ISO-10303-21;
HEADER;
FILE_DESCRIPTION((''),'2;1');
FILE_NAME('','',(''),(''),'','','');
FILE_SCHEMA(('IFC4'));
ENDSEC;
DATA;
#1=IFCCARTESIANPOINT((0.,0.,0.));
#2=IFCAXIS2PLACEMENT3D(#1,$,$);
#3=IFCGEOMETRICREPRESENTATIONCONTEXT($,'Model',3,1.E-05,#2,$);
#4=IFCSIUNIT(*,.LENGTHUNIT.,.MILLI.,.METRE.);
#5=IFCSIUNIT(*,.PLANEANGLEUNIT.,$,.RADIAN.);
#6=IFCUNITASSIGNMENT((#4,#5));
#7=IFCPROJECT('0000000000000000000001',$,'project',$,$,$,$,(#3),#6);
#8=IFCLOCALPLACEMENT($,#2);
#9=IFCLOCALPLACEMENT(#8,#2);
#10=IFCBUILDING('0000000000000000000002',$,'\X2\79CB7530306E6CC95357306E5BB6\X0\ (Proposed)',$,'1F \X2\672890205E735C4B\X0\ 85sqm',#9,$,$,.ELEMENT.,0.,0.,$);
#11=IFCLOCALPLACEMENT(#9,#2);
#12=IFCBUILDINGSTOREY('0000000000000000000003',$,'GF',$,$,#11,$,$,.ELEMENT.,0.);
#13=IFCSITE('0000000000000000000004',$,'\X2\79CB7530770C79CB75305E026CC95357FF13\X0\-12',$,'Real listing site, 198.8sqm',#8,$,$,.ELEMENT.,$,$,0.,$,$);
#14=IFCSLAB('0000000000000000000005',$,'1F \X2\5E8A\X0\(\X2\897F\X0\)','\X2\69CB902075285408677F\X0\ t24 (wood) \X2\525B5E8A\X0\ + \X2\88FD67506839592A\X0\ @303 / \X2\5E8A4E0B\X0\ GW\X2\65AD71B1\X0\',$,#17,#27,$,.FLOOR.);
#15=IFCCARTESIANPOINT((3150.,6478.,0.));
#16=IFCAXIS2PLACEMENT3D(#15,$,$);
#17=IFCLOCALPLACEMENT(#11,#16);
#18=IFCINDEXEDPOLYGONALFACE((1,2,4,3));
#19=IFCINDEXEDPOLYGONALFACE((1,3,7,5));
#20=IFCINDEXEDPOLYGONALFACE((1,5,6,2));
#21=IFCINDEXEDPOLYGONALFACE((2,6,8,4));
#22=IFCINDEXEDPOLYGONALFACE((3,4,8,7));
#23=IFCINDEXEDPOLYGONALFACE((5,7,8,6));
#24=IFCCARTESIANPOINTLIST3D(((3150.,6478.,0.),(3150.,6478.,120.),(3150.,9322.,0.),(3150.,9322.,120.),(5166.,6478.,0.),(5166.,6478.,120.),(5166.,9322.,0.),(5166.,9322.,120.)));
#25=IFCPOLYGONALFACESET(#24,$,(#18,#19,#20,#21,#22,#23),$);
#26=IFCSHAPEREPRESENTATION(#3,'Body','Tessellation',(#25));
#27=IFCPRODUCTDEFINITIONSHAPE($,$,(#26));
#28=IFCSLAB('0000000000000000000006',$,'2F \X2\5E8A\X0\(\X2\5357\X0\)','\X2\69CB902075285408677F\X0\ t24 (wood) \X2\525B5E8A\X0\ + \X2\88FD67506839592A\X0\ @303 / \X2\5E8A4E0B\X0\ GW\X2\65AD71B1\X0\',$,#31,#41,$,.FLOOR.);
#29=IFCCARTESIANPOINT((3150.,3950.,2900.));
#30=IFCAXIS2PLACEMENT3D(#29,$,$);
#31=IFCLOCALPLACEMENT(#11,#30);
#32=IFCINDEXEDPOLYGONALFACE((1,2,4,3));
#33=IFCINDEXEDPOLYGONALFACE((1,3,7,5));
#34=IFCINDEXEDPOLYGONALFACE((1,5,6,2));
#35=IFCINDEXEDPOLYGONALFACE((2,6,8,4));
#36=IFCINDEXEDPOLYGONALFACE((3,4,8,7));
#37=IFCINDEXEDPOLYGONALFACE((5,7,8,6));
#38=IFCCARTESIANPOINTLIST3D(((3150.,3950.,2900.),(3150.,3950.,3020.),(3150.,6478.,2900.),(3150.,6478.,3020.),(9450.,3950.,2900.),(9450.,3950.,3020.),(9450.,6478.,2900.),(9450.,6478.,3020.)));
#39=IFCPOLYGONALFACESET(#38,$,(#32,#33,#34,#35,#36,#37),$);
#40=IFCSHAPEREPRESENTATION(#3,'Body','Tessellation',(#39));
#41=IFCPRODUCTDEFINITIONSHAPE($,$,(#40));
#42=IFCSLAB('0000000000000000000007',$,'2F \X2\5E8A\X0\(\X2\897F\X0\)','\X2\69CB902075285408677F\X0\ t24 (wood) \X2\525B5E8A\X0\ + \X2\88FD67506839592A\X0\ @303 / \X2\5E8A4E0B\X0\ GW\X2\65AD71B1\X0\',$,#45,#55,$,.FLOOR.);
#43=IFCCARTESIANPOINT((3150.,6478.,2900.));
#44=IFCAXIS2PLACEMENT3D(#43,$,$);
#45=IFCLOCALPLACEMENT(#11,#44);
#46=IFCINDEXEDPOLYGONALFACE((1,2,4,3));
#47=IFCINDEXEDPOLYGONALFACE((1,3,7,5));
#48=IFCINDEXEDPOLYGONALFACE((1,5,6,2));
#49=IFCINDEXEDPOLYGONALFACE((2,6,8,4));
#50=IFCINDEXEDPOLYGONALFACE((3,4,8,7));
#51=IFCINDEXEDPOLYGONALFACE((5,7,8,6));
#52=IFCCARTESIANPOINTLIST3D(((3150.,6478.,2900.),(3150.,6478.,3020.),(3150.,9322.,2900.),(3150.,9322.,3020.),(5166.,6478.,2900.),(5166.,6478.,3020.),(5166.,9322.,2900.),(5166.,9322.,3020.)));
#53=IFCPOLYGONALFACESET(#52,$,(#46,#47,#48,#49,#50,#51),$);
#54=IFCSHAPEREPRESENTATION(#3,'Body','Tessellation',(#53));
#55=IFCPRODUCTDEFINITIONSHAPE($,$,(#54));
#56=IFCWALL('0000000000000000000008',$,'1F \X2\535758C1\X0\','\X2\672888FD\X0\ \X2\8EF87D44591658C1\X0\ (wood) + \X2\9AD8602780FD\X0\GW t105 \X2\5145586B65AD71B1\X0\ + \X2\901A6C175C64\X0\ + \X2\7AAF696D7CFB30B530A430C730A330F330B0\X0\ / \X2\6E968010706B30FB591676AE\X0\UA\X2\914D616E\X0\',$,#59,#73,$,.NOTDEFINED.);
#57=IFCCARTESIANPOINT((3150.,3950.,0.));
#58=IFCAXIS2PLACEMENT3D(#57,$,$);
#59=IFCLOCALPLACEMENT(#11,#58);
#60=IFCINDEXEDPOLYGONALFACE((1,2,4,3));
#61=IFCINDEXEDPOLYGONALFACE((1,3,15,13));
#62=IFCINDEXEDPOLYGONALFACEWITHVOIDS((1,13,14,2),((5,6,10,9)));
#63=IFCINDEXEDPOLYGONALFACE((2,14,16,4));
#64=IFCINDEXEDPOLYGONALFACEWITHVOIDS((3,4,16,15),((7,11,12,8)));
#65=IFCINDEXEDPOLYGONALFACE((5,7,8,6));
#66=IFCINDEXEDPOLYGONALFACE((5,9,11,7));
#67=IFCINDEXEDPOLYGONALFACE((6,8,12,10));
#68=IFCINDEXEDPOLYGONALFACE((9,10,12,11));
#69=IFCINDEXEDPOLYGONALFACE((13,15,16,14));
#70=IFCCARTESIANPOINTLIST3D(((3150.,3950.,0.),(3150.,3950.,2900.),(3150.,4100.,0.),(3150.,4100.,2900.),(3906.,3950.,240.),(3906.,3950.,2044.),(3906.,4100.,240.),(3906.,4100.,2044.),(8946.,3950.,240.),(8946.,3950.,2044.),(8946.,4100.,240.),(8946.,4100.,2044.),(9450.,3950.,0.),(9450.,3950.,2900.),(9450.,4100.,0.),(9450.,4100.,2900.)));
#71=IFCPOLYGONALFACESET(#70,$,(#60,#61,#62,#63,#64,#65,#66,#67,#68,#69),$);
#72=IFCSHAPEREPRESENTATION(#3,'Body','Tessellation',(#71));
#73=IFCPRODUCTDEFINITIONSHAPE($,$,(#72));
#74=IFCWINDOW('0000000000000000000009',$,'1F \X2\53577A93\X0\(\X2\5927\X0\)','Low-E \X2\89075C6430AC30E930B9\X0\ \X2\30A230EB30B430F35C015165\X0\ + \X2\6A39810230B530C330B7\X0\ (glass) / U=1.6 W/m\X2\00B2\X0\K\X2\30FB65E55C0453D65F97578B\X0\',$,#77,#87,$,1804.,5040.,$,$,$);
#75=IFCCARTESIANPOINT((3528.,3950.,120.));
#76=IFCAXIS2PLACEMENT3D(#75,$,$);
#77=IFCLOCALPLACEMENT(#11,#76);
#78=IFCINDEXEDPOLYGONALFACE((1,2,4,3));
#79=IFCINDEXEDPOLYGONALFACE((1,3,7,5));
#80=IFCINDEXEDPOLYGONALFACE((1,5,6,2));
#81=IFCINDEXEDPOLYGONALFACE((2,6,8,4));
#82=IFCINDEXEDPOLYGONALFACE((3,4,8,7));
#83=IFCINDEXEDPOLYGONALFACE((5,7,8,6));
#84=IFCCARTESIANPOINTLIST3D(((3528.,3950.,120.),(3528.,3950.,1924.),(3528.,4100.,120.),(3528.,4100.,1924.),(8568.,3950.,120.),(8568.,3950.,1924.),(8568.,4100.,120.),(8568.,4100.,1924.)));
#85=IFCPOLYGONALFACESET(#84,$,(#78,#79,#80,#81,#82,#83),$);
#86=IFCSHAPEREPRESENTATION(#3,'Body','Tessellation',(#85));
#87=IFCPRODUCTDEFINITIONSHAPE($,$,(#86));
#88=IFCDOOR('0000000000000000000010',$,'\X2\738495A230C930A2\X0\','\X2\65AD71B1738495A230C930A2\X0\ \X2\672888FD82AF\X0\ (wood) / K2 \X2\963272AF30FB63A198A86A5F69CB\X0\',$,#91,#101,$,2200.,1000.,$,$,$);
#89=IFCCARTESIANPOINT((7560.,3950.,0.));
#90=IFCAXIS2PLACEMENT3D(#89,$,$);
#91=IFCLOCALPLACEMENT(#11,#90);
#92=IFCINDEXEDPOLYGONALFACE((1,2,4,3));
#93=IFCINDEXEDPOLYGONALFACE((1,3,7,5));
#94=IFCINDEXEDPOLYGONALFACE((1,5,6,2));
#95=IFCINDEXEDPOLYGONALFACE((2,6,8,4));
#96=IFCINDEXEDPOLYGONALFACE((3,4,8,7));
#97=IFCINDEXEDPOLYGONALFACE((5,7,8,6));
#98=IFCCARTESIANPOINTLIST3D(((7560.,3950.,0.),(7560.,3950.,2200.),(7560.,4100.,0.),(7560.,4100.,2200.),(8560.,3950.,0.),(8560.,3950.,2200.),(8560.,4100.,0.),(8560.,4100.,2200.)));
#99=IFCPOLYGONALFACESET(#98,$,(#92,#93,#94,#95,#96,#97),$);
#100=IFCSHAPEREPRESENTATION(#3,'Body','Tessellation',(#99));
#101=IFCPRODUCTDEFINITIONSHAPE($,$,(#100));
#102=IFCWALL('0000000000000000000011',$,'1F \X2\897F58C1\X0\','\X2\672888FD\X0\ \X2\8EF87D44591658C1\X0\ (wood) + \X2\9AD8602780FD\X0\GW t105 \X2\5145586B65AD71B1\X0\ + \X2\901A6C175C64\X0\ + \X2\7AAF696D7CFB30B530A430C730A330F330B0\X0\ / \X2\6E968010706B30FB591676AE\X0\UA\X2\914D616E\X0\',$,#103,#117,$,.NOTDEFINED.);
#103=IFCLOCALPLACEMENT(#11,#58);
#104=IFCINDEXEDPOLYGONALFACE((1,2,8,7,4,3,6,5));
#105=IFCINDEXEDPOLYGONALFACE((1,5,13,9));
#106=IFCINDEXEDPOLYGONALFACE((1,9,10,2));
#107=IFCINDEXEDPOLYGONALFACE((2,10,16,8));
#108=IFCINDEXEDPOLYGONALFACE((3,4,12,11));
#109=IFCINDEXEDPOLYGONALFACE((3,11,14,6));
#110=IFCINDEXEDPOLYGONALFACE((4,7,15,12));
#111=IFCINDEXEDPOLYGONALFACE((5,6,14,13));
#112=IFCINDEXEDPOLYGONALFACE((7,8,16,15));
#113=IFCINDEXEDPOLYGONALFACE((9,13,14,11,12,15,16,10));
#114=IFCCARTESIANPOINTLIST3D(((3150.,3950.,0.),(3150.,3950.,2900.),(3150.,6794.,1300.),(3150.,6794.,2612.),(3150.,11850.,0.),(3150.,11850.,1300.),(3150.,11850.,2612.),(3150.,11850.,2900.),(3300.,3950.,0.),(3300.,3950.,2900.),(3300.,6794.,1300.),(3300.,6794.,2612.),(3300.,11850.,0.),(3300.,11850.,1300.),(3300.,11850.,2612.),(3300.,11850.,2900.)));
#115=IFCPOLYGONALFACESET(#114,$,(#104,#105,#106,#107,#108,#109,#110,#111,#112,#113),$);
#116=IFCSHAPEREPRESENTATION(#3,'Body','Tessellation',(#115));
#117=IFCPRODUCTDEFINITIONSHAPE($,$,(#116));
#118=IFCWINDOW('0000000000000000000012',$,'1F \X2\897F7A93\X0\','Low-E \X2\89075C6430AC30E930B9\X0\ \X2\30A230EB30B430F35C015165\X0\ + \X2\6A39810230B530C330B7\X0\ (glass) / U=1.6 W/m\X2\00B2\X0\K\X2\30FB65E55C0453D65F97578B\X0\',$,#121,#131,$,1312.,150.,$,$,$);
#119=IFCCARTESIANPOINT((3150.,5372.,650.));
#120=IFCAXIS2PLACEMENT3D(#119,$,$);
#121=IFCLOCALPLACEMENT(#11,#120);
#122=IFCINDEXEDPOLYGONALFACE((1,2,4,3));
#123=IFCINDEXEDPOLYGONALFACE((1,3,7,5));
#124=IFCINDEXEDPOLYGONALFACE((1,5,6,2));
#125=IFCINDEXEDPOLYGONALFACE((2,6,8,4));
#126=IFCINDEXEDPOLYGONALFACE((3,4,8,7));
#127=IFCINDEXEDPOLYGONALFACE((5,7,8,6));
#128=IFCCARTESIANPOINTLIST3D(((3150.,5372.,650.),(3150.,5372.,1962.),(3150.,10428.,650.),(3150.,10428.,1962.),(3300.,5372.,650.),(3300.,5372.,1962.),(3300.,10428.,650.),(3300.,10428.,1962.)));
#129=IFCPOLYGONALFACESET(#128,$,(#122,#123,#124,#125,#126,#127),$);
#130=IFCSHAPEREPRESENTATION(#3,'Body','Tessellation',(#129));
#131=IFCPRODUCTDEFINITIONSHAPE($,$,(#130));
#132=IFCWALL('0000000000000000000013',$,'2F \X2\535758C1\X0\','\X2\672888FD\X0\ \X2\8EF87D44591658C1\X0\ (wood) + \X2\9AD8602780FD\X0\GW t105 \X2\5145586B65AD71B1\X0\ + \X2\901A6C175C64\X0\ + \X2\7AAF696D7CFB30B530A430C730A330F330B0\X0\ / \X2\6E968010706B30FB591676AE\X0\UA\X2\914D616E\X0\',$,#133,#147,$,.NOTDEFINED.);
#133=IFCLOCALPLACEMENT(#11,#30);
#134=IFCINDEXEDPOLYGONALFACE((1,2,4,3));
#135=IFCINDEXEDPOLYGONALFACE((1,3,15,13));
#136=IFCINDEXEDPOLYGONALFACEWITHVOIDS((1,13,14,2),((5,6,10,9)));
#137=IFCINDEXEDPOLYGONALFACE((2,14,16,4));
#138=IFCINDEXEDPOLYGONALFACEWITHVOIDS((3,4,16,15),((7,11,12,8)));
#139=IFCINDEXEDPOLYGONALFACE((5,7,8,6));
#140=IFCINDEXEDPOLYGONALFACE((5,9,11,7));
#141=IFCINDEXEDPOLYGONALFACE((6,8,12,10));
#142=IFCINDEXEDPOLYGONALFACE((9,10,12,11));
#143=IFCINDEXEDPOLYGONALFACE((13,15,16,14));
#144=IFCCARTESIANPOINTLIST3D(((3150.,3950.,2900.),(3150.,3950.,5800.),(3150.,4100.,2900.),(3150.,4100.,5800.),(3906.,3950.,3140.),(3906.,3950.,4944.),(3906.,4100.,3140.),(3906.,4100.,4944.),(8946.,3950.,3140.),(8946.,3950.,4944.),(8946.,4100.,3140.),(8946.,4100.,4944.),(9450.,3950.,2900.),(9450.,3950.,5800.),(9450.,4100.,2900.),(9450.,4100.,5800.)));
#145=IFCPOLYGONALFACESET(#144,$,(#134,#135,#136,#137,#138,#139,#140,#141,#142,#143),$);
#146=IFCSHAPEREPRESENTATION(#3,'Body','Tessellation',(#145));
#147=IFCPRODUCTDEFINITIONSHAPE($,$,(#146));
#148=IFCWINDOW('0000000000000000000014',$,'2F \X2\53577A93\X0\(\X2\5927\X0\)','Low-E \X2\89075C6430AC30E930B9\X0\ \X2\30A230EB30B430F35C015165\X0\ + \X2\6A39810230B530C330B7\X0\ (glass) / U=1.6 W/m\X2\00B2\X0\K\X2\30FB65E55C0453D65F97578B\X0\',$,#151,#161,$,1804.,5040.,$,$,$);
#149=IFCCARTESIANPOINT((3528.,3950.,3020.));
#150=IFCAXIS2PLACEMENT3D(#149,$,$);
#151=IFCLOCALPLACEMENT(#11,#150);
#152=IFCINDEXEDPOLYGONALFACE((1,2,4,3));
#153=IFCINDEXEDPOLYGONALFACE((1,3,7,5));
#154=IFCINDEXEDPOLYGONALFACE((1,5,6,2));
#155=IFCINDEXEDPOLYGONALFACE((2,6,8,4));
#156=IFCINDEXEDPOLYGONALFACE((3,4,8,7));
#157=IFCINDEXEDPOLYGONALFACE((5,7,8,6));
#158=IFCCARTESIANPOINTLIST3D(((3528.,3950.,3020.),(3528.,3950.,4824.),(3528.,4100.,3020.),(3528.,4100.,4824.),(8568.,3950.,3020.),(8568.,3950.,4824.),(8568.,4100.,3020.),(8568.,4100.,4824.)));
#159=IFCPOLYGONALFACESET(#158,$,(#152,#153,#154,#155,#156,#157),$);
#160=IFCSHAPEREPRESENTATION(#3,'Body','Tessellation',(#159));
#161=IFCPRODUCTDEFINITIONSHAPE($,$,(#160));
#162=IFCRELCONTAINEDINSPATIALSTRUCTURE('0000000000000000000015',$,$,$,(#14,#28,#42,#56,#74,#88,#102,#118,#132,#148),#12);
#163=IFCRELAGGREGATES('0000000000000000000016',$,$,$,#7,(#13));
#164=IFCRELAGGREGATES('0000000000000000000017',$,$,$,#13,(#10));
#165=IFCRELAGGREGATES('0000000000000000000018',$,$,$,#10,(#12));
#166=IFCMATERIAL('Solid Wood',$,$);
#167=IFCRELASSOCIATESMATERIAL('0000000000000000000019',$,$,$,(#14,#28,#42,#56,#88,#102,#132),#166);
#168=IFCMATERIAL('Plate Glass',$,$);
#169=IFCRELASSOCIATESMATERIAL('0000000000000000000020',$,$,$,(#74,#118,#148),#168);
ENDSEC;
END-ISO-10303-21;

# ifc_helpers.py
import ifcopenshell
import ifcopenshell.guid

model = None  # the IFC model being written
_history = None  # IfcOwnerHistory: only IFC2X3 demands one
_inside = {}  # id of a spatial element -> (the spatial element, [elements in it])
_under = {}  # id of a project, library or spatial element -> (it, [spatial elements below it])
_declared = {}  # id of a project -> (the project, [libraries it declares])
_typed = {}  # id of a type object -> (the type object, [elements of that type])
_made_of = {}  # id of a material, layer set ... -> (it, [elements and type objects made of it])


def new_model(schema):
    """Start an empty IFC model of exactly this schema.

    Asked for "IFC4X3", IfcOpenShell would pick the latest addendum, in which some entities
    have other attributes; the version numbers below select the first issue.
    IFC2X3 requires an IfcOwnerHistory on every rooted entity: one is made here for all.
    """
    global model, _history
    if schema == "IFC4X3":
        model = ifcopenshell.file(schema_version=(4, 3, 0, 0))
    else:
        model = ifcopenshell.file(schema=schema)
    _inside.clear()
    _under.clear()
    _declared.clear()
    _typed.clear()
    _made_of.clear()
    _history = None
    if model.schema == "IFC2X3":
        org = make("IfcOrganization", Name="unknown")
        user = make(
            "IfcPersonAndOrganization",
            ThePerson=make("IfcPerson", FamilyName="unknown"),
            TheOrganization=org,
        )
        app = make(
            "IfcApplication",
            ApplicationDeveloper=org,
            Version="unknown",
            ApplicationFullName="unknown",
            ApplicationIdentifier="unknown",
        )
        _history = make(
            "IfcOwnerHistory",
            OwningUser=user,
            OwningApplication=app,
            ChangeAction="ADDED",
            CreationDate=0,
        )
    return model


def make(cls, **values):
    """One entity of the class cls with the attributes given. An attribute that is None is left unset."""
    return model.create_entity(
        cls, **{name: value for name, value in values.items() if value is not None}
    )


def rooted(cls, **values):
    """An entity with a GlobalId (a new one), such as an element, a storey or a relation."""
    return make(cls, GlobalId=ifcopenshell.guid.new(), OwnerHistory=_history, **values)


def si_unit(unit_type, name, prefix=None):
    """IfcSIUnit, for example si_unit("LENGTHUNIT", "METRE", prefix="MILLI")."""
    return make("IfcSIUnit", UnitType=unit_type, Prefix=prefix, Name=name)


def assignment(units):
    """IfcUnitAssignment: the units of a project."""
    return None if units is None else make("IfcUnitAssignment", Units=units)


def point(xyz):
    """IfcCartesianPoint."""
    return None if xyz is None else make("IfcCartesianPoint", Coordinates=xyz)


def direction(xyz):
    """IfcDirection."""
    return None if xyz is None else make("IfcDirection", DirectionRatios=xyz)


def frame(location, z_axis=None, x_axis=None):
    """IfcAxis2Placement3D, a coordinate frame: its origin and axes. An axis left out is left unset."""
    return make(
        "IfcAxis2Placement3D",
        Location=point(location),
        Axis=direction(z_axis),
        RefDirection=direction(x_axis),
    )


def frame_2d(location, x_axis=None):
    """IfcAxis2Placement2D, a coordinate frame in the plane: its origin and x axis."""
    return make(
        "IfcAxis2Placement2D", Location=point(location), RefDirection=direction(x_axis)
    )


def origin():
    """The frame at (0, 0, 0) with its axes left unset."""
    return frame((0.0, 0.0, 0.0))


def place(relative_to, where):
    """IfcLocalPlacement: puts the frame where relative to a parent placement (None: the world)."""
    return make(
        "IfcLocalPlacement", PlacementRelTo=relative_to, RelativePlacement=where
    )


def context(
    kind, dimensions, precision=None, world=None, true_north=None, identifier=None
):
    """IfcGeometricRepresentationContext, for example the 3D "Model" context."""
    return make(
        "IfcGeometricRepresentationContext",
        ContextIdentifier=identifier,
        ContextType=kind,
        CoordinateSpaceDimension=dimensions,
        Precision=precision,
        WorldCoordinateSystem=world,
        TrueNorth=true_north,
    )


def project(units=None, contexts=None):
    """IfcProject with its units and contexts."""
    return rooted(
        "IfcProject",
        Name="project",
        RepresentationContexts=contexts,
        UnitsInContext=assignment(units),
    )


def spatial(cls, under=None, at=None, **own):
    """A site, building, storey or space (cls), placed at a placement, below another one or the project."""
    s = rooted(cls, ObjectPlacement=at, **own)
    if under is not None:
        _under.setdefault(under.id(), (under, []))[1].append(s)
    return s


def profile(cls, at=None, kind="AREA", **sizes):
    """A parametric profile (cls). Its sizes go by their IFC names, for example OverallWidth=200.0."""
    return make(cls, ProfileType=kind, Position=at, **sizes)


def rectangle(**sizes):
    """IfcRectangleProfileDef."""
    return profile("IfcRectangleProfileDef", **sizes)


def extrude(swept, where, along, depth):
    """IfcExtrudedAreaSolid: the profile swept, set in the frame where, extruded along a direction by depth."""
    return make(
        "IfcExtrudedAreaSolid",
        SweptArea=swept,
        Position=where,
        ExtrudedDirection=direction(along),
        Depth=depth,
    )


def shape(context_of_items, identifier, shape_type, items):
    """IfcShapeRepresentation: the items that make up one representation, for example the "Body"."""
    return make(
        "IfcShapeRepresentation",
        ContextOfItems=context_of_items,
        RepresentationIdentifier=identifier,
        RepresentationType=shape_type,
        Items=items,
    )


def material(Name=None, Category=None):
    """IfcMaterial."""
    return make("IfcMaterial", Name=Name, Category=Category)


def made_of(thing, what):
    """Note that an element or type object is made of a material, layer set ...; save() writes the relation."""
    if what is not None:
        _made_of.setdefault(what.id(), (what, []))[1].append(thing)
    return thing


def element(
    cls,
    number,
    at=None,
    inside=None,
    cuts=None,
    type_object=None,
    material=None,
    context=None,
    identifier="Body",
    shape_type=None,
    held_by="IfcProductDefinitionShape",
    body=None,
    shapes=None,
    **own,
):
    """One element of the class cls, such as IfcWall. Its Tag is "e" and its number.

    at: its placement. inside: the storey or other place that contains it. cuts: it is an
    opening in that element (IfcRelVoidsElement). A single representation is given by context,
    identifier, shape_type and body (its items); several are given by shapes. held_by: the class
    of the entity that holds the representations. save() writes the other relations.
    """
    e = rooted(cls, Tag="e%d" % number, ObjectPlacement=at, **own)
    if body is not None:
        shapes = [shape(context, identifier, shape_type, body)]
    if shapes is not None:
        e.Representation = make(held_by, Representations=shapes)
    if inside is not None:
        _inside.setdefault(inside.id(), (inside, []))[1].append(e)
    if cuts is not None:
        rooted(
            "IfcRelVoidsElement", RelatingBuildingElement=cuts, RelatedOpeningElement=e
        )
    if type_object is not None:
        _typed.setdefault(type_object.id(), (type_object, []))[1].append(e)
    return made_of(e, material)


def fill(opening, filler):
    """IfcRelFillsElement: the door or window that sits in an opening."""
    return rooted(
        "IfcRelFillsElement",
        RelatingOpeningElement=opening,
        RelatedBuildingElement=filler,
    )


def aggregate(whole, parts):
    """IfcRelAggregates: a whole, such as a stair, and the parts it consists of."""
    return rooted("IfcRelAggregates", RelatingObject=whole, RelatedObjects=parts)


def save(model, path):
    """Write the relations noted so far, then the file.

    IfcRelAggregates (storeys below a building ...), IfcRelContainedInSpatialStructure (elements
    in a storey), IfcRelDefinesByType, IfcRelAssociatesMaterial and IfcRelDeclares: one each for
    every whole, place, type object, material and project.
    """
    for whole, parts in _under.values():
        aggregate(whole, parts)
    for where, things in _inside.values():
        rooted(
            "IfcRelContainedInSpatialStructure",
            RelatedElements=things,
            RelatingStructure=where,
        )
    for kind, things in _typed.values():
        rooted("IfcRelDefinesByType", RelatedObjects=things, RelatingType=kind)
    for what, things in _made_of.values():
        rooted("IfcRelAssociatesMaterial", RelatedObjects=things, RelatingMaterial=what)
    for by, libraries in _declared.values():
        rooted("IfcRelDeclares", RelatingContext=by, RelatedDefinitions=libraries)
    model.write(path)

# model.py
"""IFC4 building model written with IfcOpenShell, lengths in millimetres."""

from ifc_helpers import new_model, si_unit, frame, frame_2d, origin, place, context, project, spatial, rectangle, extrude, material, element, fill, save


model = new_model("IFC4")

# Units and contexts
model_context = context("Model", 3, precision=1e-05, world=origin())
ifc_project = project(units=[si_unit("LENGTHUNIT", "METRE", prefix="MILLI"), si_unit("PLANEANGLEUNIT", "RADIAN")], contexts=[model_context])

# Site, building, storey
site_placement = place(None, origin())
site = spatial("IfcSite", under=ifc_project, at=site_placement, Name="秋田県秋田市泉南３-12", ObjectType="Real listing site, 198.8sqm", CompositionType="ELEMENT", RefElevation=0.0)
building_placement = place(site_placement, origin())
building = spatial("IfcBuilding", under=site, at=building_placement, Name="秋田の泉南の家 (Proposed)", ObjectType="1F 木造平屋 85sqm", CompositionType="ELEMENT", ElevationOfRefHeight=0.0, ElevationOfTerrain=0.0)
storey_placement = place(building_placement, origin())
storey = spatial("IfcBuildingStorey", under=building, at=storey_placement, Name="GF", CompositionType="ELEMENT", Elevation=0.0)

# Slabs
ifc_material_1 = material(Name="Solid Wood")
slab_1_placement = place(storey_placement, frame((3150.0, 6478.0, 0.0)))
element("IfcSlab", 1, at=slab_1_placement, inside=storey, material=ifc_material_1, Name="1F 床(西)", Description="構造用合板 t24 (wood) 剛床 + 製材根太 @303 / 床下 GW断熱", PredefinedType="FLOOR", context=model_context, shape_type="SweptSolid", body=[
    extrude(rectangle(XDim=2016.0, YDim=2844.0, at=frame_2d((1008.0, 1422.0))), frame((3150.0, 6478.0, 0.0)), (0.0, 0.0, 1.0), 120.0),
])
slab_2_placement = place(storey_placement, frame((3150.0, 3950.0, 2900.0)))
element("IfcSlab", 2, at=slab_2_placement, inside=storey, material=ifc_material_1, Name="2F 床(南)", Description="構造用合板 t24 (wood) 剛床 + 製材根太 @303 / 床下 GW断熱", PredefinedType="FLOOR", context=model_context, shape_type="SweptSolid", body=[
    extrude(rectangle(XDim=6300.0, YDim=2528.0, at=frame_2d((3150.0, 1264.0))), frame((3150.0, 3950.0, 2900.0)), (0.0, 0.0, 1.0), 120.0),
])
slab_3_placement = place(storey_placement, frame((3150.0, 6478.0, 2900.0)))
element("IfcSlab", 3, at=slab_3_placement, inside=storey, material=ifc_material_1, Name="2F 床(西)", Description="構造用合板 t24 (wood) 剛床 + 製材根太 @303 / 床下 GW断熱", PredefinedType="FLOOR", context=model_context, shape_type="SweptSolid", body=[
    extrude(rectangle(XDim=2016.0, YDim=2844.0, at=frame_2d((1008.0, 1422.0))), frame((3150.0, 6478.0, 2900.0)), (0.0, 0.0, 1.0), 120.0),
])

# Wall, openings, window, door
wall_1_placement = place(storey_placement, frame((3150.0, 3950.0, 0.0)))
wall_1 = element("IfcWall", 4, at=wall_1_placement, inside=storey, material=ifc_material_1, Name="1F 南壁", Description="木製 軸組外壁 (wood) + 高性能GW t105 充填断熱 + 通気層 + 窯業系サイディング / 準耐火・外皮UA配慮", PredefinedType="NOTDEFINED", context=model_context, shape_type="SweptSolid", body=[
    extrude(rectangle(XDim=6300.0, YDim=150.0, at=frame_2d((3150.0, 75.0))), frame((3150.0, 3950.0, 0.0)), (0.0, 0.0, 1.0), 2900.0),
])
opening_1_placement = place(storey_placement, frame((3528.0, 3950.0, 120.0)))
opening_1 = element("IfcOpeningElement", 5, at=opening_1_placement, cuts=wall_1, PredefinedType="NOTDEFINED", context=model_context, shape_type="SweptSolid", body=[
    extrude(rectangle(XDim=5040.0, YDim=150.0, at=frame_2d((2520.0, 75.0))), frame((3528.0, 3950.0, 120.0)), (0.0, 0.0, 1.0), 1804.0),
])
opening_2_placement = place(storey_placement, frame((7560.0, 3950.0, 0.0)))
opening_2 = element("IfcOpeningElement", 6, at=opening_2_placement, cuts=wall_1, PredefinedType="NOTDEFINED", context=model_context, shape_type="SweptSolid", body=[
    extrude(rectangle(XDim=1000.0, YDim=150.0, at=frame_2d((500.0, 75.0))), frame((7560.0, 3950.0, 0.0)), (0.0, 0.0, 1.0), 2200.0),
])
ifc_material_2 = material(Name="Plate Glass")
window_1_placement = place(storey_placement, frame((3528.0, 3950.0, 120.0)))
window_1 = element("IfcWindow", 7, at=window_1_placement, inside=storey, material=ifc_material_2, Name="1F 南窓(大)", Description="Low-E 複層ガラス アルゴン封入 + 樹脂サッシ (glass) / U=1.6 W/m²K・日射取得型", OverallHeight=1804.0, OverallWidth=5040.0, context=model_context, shape_type="SweptSolid", body=[
    extrude(rectangle(XDim=5040.0, YDim=150.0, at=frame_2d((2520.0, 75.0))), frame((3528.0, 3950.0, 120.0)), (0.0, 0.0, 1.0), 1804.0),
])
fill(opening_1, window_1)
door_placement = place(storey_placement, frame((7560.0, 3950.0, 0.0)))
door = element("IfcDoor", 8, at=door_placement, inside=storey, material=ifc_material_1, Name="玄関ドア", Description="断熱玄関ドア 木製芯 (wood) / K2 防犯・採風機構", OverallHeight=2200.0, OverallWidth=1000.0, context=model_context, shape_type="SweptSolid", body=[
    extrude(rectangle(XDim=1000.0, YDim=150.0, at=frame_2d((500.0, 75.0))), frame((7560.0, 3950.0, 0.0)), (0.0, 0.0, 1.0), 2200.0),
])
fill(opening_2, door)

# Walls, openings, windows
wall_2_placement = place(storey_placement, frame((3150.0, 3950.0, 0.0)))
wall_2 = element("IfcWall", 9, at=wall_2_placement, inside=storey, material=ifc_material_1, Name="1F 西壁", Description="木製 軸組外壁 (wood) + 高性能GW t105 充填断熱 + 通気層 + 窯業系サイディング / 準耐火・外皮UA配慮", PredefinedType="NOTDEFINED", context=model_context, shape_type="SweptSolid", body=[
    extrude(rectangle(XDim=150.0, YDim=7900.0, at=frame_2d((75.0, 3950.0))), frame((3150.0, 3950.0, 0.0)), (0.0, 0.0, 1.0), 2900.0),
])
opening_3_placement = place(storey_placement, frame((3150.0, 5372.0, 650.0)))
opening_3 = element("IfcOpeningElement", 10, at=opening_3_placement, cuts=wall_2, PredefinedType="NOTDEFINED", context=model_context, shape_type="SweptSolid", body=[
    extrude(rectangle(XDim=150.0, YDim=5056.0, at=frame_2d((75.0, 2528.0))), frame((3150.0, 5372.0, 650.0)), (0.0, 0.0, 1.0), 1312.0),
])
window_2_placement = place(storey_placement, frame((3150.0, 5372.0, 650.0)))
window_2 = element("IfcWindow", 11, at=window_2_placement, inside=storey, material=ifc_material_2, Name="1F 西窓", Description="Low-E 複層ガラス アルゴン封入 + 樹脂サッシ (glass) / U=1.6 W/m²K・日射取得型", OverallHeight=1312.0, OverallWidth=150.0, context=model_context, shape_type="SweptSolid", body=[
    extrude(rectangle(XDim=150.0, YDim=5056.0, at=frame_2d((75.0, 2528.0))), frame((3150.0, 5372.0, 650.0)), (0.0, 0.0, 1.0), 1312.0),
])
fill(opening_3, window_2)
wall_3_placement = place(storey_placement, frame((3150.0, 3950.0, 2900.0)))
wall_3 = element("IfcWall", 12, at=wall_3_placement, inside=storey, material=ifc_material_1, Name="2F 南壁", Description="木製 軸組外壁 (wood) + 高性能GW t105 充填断熱 + 通気層 + 窯業系サイディング / 準耐火・外皮UA配慮", PredefinedType="NOTDEFINED", context=model_context, shape_type="SweptSolid", body=[
    extrude(rectangle(XDim=6300.0, YDim=150.0, at=frame_2d((3150.0, 75.0))), frame((3150.0, 3950.0, 2900.0)), (0.0, 0.0, 1.0), 2900.0),
])
opening_4_placement = place(storey_placement, frame((3528.0, 3950.0, 3020.0)))
opening_4 = element("IfcOpeningElement", 13, at=opening_4_placement, cuts=wall_3, PredefinedType="NOTDEFINED", context=model_context, shape_type="SweptSolid", body=[
    extrude(rectangle(XDim=5040.0, YDim=150.0, at=frame_2d((2520.0, 75.0))), frame((3528.0, 3950.0, 3020.0)), (0.0, 0.0, 1.0), 1804.0),
])
window_3_placement = place(storey_placement, frame((3528.0, 3950.0, 3020.0)))
window_3 = element("IfcWindow", 14, at=window_3_placement, inside=storey, material=ifc_material_2, Name="2F 南窓(大)", Description="Low-E 複層ガラス アルゴン封入 + 樹脂サッシ (glass) / U=1.6 W/m²K・日射取得型", OverallHeight=1804.0, OverallWidth=5040.0, context=model_context, shape_type="SweptSolid", body=[
    extrude(rectangle(XDim=5040.0, YDim=150.0, at=frame_2d((2520.0, 75.0))), frame((3528.0, 3950.0, 3020.0)), (0.0, 0.0, 1.0), 1804.0),
])
fill(opening_4, window_3)

save(model, "model.ifc")
